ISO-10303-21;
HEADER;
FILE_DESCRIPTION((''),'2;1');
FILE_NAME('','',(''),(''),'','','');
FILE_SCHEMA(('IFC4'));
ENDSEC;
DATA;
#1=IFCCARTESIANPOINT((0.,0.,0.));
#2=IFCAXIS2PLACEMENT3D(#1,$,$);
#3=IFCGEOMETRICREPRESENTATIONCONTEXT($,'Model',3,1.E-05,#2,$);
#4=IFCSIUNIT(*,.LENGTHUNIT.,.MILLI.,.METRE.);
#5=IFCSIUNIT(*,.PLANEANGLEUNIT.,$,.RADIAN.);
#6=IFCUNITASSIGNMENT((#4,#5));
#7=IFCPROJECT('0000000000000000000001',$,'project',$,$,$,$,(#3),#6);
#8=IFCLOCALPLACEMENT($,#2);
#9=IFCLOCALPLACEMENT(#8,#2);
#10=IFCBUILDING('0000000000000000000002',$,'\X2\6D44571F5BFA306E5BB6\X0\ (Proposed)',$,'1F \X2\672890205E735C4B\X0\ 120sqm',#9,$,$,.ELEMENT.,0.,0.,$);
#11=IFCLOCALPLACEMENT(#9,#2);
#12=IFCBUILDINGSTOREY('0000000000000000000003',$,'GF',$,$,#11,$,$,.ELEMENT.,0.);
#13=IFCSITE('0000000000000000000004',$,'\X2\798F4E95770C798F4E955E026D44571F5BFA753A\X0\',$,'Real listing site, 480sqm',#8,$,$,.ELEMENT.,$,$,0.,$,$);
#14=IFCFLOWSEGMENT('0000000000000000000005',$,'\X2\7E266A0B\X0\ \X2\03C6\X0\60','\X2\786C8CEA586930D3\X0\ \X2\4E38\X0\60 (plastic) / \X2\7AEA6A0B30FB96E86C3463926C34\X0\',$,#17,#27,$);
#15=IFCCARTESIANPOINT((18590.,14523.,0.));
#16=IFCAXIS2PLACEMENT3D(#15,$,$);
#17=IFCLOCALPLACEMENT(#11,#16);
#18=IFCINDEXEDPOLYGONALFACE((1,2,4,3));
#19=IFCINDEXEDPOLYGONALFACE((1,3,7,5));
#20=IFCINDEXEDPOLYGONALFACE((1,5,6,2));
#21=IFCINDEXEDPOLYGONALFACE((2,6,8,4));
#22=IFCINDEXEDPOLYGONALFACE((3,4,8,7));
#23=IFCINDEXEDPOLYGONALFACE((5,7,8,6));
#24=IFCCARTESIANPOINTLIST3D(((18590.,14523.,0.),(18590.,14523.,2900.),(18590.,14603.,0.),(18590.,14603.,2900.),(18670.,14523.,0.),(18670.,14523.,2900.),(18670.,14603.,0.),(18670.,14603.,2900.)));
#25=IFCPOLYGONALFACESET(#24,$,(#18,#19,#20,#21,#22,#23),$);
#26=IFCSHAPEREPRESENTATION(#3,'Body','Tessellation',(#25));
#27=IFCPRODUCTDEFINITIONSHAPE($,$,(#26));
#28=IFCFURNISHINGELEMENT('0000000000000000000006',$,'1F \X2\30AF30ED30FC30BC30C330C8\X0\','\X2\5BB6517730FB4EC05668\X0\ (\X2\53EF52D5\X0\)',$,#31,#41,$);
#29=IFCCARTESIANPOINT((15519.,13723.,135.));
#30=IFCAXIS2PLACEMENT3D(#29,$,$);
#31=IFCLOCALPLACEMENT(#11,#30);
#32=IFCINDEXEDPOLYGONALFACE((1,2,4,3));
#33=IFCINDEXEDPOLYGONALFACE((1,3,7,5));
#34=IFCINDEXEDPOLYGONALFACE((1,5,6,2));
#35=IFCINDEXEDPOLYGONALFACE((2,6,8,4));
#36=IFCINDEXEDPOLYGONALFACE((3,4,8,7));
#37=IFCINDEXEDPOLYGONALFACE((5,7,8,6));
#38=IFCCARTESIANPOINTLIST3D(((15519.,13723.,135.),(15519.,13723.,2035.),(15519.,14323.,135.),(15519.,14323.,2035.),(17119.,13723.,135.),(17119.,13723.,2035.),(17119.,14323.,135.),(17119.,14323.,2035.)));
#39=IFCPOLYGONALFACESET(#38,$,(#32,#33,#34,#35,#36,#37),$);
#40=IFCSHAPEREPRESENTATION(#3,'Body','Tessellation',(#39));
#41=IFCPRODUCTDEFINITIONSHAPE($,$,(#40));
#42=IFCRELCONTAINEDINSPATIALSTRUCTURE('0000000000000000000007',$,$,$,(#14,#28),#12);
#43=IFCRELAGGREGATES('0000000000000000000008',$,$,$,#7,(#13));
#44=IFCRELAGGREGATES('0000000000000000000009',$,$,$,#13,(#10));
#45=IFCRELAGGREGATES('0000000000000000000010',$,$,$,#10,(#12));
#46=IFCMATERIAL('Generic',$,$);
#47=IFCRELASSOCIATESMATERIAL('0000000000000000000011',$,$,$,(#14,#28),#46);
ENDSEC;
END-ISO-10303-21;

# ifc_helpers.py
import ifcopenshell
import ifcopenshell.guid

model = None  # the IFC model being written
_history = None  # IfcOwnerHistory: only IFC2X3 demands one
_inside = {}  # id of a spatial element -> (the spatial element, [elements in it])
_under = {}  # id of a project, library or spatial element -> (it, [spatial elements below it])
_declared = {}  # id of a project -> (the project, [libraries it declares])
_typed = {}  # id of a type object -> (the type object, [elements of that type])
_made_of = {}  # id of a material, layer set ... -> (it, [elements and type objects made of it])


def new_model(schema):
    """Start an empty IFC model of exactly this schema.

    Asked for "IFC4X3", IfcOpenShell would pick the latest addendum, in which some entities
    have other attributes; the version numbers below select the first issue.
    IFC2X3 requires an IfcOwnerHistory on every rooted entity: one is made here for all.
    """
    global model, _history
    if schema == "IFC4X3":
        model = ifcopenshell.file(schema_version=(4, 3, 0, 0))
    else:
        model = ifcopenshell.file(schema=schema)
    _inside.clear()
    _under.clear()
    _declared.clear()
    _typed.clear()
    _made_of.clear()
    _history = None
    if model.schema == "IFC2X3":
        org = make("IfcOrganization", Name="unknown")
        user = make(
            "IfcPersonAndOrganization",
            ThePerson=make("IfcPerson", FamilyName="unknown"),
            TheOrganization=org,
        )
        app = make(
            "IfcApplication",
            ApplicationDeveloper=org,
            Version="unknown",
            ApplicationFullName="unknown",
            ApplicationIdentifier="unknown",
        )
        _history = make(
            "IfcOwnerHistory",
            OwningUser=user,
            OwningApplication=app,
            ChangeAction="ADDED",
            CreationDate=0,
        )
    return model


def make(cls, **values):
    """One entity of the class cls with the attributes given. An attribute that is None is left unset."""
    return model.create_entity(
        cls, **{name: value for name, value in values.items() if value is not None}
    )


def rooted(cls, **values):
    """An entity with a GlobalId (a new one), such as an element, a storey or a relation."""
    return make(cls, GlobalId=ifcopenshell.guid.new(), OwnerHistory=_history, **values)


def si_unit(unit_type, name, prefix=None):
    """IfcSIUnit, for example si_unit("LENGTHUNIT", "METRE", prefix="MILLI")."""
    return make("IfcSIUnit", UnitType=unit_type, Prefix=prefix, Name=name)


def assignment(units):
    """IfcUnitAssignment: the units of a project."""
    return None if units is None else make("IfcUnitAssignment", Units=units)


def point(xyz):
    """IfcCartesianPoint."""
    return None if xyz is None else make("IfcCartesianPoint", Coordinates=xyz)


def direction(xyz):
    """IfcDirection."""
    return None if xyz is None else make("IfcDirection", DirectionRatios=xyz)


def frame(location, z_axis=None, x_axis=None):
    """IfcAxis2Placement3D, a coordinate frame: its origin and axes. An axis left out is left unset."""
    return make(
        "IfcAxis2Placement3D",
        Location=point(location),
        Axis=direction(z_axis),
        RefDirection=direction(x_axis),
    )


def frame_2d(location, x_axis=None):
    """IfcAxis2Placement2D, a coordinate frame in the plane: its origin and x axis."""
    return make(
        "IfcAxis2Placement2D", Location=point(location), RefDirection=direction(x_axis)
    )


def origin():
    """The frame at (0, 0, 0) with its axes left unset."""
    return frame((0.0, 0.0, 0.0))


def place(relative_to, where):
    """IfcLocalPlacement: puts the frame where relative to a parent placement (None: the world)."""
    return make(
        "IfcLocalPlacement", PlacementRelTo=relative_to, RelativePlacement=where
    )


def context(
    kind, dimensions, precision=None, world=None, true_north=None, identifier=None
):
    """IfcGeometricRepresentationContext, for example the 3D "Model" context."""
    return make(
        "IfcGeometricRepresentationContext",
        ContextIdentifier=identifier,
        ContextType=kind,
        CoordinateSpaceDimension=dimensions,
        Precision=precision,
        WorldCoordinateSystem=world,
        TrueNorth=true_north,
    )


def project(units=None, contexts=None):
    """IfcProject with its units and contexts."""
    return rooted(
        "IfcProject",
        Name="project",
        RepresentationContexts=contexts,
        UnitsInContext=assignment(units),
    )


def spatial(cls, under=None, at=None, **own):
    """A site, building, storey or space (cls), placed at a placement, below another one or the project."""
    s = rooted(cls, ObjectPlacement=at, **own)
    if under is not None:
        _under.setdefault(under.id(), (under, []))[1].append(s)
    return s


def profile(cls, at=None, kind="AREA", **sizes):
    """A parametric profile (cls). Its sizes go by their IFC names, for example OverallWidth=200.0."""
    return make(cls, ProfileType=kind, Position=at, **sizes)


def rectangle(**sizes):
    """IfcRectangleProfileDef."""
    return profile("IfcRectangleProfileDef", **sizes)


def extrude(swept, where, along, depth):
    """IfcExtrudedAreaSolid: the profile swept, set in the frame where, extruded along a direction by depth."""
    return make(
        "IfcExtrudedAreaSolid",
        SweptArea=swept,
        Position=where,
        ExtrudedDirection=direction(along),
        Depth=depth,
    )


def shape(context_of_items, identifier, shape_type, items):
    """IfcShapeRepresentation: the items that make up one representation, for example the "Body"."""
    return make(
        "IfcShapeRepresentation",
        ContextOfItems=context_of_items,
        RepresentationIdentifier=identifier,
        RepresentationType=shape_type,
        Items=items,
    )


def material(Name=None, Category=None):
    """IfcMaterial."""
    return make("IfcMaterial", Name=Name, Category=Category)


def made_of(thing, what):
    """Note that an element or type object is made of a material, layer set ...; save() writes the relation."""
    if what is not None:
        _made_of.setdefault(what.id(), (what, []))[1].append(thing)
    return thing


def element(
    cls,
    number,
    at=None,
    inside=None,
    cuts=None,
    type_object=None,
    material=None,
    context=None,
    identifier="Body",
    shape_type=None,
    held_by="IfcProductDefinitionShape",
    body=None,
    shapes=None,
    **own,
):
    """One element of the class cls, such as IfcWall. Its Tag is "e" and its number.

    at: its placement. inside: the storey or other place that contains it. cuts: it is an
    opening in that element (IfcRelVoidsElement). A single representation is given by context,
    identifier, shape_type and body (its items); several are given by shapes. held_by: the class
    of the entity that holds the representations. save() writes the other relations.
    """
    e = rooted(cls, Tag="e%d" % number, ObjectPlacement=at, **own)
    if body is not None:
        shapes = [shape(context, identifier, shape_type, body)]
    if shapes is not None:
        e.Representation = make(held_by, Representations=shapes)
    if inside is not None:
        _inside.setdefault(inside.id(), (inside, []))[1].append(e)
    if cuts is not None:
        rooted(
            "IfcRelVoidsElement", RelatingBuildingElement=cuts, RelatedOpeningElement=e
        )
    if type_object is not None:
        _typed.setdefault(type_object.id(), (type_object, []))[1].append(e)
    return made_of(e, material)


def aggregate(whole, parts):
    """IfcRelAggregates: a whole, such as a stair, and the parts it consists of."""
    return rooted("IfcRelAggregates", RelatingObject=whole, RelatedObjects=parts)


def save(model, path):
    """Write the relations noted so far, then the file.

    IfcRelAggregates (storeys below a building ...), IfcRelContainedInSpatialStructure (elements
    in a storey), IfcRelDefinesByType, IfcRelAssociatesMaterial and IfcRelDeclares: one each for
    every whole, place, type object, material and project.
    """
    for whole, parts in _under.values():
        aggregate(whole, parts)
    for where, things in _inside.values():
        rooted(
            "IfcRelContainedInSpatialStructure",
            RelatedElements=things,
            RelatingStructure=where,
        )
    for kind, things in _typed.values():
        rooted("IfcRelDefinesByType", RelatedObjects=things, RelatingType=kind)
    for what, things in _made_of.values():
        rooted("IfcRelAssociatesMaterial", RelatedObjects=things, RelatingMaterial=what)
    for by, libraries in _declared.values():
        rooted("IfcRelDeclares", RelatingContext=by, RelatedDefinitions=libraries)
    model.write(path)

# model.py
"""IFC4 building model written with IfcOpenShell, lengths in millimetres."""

from ifc_helpers import new_model, si_unit, frame, frame_2d, origin, place, context, project, spatial, rectangle, extrude, material, element, save


model = new_model("IFC4")

# Units and contexts
model_context = context("Model", 3, precision=1e-05, world=origin())
ifc_project = project(units=[si_unit("LENGTHUNIT", "METRE", prefix="MILLI"), si_unit("PLANEANGLEUNIT", "RADIAN")], contexts=[model_context])

# Site, building, storey
site_placement = place(None, origin())
site = spatial("IfcSite", under=ifc_project, at=site_placement, Name="福井県福井市浄土寺町", ObjectType="Real listing site, 480sqm", CompositionType="ELEMENT", RefElevation=0.0)
building_placement = place(site_placement, origin())
building = spatial("IfcBuilding", under=site, at=building_placement, Name="浄土寺の家 (Proposed)", ObjectType="1F 木造平屋 120sqm", CompositionType="ELEMENT", ElevationOfRefHeight=0.0, ElevationOfTerrain=0.0)
storey_placement = place(building_placement, origin())
storey = spatial("IfcBuildingStorey", under=building, at=storey_placement, Name="GF", CompositionType="ELEMENT", Elevation=0.0)

# Shared definitions
ifc_material_1 = material(Name="Generic")

# Flow segment
flow_segment_placement = place(storey_placement, frame((18590.0, 14523.0, 0.0)))
element("IfcFlowSegment", 1, at=flow_segment_placement, inside=storey, material=ifc_material_1, Name="縦樋 φ60", Description="硬質塩ビ 丸60 (plastic) / 竪樋・雨水排水", context=model_context, shape_type="SweptSolid", body=[
    extrude(rectangle(XDim=80.0, YDim=80.0, at=frame_2d((40.0, 40.0))), frame((18590.0, 14523.0, 0.0)), (0.0, 0.0, 1.0), 2900.0),
])

# Furnishing element
furnishing_placement = place(storey_placement, frame((15519.0, 13723.0, 135.0)))
element("IfcFurnishingElement", 2, at=furnishing_placement, inside=storey, material=ifc_material_1, Name="1F クローゼット", Description="家具・什器 (可動)", context=model_context, shape_type="SweptSolid", body=[
    extrude(rectangle(XDim=1600.0, YDim=600.0, at=frame_2d((800.0, 300.0))), frame((15519.0, 13723.0, 135.0)), (0.0, 0.0, 1.0), 1900.0),
])

save(model, "model.ifc")
